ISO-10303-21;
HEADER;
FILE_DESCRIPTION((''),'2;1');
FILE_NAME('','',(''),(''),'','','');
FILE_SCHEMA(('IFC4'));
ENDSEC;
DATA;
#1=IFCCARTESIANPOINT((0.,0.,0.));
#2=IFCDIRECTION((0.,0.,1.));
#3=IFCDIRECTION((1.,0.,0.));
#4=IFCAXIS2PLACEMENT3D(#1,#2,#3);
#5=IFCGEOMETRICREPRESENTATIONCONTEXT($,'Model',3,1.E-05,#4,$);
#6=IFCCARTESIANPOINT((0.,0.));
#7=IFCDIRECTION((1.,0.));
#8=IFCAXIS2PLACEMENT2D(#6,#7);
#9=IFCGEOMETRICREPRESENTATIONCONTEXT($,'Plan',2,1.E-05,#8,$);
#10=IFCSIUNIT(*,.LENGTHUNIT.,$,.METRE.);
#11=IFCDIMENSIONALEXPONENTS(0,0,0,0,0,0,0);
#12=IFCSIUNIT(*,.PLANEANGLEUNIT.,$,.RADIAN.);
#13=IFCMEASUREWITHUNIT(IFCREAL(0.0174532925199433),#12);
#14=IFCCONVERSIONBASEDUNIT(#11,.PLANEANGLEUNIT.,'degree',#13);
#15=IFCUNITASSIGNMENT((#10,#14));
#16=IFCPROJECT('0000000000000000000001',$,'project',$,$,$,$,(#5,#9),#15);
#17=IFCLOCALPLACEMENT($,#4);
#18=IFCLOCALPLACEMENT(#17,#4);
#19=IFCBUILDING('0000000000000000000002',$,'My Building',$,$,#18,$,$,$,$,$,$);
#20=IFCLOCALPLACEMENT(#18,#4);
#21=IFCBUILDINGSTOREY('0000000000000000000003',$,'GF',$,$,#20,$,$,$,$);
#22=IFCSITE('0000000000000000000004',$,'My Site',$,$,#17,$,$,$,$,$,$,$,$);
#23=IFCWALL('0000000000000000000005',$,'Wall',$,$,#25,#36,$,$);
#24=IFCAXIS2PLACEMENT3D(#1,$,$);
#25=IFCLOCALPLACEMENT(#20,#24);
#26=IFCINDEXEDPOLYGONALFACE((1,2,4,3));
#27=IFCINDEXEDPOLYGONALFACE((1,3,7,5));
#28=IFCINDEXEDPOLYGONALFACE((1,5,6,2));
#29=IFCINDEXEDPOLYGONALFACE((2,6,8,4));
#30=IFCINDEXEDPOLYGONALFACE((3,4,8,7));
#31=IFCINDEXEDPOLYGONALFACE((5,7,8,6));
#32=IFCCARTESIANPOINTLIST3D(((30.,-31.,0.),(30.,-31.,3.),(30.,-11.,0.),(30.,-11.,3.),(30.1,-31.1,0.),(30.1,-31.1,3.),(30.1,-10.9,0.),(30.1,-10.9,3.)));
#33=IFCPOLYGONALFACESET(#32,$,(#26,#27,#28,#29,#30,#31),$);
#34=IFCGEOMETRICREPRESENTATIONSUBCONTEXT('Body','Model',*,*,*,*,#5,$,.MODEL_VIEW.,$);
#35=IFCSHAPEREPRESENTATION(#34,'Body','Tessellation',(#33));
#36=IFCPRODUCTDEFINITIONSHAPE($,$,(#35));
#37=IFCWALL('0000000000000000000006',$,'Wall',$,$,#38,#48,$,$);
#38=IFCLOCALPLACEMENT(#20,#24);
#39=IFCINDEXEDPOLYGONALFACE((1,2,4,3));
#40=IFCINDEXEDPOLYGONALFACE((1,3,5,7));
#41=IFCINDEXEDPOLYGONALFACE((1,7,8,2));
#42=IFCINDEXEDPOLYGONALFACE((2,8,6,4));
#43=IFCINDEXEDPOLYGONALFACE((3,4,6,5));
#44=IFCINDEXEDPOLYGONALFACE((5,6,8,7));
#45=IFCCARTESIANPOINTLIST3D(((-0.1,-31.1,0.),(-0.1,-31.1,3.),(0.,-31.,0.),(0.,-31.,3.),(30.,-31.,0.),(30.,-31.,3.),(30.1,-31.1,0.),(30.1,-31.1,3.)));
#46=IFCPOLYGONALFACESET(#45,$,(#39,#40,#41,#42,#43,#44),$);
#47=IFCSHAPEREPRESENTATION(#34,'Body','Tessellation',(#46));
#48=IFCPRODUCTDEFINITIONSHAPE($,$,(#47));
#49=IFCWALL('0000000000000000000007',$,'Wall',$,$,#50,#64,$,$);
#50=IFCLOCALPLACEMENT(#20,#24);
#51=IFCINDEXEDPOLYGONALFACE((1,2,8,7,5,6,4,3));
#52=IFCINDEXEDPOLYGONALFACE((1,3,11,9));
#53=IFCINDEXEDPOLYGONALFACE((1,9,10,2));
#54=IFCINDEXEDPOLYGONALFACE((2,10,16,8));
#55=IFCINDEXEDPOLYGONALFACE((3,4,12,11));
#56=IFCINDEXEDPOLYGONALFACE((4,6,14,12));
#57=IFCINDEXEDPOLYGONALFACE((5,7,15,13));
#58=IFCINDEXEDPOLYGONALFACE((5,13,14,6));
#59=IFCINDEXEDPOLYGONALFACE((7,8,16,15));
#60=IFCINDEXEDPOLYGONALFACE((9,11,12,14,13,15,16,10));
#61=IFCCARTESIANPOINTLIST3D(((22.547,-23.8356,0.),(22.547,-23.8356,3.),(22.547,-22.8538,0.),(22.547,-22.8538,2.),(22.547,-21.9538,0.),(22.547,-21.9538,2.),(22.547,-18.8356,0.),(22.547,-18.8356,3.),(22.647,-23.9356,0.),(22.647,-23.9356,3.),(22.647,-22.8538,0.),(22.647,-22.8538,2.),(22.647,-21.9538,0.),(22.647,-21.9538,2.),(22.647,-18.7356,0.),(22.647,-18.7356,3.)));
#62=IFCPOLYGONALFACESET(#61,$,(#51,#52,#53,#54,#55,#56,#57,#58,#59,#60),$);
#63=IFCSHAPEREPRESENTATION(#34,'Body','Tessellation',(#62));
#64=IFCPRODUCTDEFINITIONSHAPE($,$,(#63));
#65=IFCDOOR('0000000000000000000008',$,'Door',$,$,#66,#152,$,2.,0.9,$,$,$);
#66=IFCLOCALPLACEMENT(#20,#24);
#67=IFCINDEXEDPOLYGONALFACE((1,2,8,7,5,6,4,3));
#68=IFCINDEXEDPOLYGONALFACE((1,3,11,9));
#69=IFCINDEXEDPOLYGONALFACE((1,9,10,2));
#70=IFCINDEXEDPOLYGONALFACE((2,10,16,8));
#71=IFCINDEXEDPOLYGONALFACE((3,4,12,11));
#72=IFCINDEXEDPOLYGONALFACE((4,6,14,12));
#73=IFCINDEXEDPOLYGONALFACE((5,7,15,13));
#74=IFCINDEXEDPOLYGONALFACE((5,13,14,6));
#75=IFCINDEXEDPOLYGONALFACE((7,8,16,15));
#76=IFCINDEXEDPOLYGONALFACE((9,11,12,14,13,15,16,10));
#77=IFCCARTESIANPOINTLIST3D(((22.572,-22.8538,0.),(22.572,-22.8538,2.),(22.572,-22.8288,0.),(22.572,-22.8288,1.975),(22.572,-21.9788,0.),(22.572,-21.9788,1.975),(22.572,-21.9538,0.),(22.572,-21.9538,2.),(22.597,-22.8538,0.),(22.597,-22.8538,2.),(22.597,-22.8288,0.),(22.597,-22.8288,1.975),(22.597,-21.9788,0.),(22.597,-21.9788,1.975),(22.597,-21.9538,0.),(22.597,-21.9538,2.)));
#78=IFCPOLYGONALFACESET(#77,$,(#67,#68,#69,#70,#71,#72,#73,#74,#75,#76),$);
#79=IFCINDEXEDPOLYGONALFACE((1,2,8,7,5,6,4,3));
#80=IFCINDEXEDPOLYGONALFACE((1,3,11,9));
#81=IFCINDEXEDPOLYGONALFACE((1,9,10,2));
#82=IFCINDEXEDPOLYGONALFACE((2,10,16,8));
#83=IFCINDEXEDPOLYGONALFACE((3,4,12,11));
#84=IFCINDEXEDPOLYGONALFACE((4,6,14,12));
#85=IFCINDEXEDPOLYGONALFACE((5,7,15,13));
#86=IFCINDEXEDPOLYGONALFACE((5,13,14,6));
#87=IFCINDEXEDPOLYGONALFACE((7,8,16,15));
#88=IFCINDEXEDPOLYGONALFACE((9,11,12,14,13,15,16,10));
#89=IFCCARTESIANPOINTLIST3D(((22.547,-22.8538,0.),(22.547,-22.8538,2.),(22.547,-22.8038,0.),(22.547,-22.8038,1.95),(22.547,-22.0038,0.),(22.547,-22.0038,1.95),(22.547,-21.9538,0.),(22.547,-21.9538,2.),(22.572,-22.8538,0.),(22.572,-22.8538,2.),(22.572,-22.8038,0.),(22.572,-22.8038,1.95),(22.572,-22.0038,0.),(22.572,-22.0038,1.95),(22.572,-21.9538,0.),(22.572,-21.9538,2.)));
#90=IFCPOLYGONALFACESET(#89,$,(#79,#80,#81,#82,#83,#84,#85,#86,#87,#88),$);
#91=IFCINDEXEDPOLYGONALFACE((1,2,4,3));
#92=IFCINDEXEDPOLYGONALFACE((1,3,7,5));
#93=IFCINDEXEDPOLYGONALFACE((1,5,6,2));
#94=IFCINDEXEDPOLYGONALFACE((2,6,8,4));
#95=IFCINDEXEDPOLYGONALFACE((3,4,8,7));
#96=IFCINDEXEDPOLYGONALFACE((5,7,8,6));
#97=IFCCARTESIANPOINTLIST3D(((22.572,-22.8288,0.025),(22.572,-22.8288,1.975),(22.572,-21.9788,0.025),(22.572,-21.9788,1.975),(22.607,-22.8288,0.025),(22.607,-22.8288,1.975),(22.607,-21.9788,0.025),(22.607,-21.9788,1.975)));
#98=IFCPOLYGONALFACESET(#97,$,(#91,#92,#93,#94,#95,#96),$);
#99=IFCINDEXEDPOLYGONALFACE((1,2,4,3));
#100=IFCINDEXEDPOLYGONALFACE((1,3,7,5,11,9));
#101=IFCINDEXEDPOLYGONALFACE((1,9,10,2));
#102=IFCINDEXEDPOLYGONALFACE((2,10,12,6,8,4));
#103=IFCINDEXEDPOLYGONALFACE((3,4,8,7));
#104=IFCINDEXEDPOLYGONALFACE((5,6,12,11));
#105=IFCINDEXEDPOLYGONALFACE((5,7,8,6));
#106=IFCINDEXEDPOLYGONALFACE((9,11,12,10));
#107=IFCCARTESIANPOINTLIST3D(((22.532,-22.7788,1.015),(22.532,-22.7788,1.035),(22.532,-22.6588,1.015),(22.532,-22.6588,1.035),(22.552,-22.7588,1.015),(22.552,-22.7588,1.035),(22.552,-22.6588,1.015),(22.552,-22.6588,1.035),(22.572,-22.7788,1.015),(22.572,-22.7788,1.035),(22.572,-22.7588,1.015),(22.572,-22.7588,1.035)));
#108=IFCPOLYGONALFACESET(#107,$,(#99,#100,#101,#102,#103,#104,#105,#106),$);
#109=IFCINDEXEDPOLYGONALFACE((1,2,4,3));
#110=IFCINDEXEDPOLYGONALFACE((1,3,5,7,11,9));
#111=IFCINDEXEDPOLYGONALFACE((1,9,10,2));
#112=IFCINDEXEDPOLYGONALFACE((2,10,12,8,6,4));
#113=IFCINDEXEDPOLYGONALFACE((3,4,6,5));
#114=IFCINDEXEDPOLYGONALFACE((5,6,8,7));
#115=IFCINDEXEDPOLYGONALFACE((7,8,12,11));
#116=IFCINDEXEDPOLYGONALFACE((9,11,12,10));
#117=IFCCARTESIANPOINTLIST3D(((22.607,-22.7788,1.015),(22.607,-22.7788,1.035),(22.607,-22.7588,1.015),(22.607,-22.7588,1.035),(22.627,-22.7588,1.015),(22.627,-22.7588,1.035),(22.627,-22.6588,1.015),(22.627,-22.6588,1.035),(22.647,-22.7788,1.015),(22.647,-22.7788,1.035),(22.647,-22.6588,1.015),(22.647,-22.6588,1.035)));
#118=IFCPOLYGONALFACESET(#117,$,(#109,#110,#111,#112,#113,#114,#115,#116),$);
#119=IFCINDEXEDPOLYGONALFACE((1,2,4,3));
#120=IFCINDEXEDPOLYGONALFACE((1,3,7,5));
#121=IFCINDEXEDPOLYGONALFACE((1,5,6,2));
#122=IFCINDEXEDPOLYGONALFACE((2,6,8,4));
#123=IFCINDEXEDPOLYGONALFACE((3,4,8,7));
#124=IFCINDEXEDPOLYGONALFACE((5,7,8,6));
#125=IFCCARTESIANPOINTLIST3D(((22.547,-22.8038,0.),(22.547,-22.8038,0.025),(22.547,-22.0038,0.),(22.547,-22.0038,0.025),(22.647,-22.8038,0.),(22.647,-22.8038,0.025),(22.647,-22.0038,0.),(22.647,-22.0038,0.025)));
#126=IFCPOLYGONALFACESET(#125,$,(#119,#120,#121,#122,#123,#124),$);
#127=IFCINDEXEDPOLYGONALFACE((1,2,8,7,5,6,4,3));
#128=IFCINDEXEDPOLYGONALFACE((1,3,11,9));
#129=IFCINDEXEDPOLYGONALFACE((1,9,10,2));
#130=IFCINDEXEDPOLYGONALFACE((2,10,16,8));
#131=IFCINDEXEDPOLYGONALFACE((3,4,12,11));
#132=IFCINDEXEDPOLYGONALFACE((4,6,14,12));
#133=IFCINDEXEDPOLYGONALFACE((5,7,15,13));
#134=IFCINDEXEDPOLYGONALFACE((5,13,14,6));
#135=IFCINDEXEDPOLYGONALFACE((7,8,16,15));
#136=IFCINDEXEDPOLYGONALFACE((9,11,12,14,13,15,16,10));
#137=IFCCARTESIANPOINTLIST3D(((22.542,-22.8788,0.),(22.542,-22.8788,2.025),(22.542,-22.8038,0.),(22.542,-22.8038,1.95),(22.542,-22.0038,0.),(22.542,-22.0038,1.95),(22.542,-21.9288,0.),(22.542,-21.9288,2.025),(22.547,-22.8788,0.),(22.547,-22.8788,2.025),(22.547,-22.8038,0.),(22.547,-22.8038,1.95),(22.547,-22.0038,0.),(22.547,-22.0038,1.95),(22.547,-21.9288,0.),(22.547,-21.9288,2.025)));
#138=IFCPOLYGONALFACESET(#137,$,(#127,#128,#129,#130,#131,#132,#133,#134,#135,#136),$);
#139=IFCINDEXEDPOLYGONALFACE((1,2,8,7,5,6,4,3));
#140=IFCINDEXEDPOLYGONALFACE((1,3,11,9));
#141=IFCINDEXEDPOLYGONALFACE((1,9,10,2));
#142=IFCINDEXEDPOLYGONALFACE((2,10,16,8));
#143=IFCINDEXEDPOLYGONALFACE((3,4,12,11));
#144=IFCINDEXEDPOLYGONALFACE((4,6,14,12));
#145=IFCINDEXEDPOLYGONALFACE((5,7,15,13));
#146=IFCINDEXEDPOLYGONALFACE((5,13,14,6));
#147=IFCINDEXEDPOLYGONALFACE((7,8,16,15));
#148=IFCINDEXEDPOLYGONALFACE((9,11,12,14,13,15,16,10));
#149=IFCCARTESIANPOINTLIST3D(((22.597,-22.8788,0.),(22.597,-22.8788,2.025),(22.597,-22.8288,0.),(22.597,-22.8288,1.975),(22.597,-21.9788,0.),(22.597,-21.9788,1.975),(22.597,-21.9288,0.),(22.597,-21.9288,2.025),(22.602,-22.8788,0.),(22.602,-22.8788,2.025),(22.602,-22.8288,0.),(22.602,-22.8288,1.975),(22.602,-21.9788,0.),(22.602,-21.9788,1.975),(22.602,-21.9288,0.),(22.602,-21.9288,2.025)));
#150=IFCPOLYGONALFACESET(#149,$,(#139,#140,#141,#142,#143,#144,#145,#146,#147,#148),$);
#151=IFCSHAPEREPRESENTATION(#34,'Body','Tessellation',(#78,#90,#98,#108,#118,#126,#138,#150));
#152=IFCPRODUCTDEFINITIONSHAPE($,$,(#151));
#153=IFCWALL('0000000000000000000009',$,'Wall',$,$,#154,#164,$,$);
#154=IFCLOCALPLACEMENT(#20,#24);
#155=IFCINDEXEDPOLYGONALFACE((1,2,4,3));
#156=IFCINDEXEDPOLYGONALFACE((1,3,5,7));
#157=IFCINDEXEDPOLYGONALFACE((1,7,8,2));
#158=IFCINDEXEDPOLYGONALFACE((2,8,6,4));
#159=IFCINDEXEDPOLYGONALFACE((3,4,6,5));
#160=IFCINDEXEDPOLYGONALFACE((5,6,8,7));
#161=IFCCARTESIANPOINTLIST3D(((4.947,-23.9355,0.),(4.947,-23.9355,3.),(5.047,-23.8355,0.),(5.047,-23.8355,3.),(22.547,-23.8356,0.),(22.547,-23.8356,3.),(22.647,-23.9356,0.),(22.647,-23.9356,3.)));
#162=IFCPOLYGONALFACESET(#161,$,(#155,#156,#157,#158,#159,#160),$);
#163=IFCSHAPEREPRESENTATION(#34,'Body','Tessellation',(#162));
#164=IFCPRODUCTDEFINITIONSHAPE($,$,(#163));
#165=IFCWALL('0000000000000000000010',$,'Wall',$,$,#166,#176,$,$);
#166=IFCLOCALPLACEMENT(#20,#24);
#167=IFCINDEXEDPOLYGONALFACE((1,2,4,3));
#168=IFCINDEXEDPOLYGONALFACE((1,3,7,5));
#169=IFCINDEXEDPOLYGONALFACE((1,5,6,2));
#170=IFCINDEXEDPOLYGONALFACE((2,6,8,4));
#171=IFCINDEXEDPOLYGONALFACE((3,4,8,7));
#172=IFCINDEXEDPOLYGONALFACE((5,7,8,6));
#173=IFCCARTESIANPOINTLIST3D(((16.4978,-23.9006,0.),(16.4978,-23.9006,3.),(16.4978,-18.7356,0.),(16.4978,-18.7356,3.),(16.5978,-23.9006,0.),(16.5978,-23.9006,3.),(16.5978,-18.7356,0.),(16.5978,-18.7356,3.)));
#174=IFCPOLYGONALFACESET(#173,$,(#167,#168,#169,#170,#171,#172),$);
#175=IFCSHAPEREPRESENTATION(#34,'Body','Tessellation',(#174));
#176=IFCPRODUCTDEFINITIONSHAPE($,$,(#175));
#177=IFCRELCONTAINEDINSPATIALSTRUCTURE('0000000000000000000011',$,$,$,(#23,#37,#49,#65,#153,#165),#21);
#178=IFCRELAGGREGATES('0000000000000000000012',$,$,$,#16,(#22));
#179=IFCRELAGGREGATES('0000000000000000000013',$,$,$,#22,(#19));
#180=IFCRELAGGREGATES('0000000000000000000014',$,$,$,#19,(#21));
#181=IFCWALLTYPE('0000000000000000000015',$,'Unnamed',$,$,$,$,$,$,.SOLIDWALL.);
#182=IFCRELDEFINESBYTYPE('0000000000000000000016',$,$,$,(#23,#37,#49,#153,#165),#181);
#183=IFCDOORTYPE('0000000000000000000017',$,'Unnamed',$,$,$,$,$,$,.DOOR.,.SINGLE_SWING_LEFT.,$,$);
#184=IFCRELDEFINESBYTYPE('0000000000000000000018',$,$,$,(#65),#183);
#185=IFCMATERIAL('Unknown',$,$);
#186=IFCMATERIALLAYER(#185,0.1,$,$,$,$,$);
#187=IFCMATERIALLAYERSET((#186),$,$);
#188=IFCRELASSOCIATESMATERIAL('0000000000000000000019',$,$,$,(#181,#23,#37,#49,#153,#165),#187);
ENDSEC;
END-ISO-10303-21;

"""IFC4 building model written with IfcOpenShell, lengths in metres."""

from ifc_helpers import new_model, entity, si_unit, converted_unit, frame, origin_with_axes, origin_2d_with_axis, place, context, subcontext, project, spatial, line, indexed_curve, outline, extrude, shape, source, transform, mapped, material, layer, layer_set, layer_usage, type_object, type_shapes, element, fill, save


model = new_model("IFC4")

# Units and contexts
model_context = context("Model", 3, precision=1e-05, world=origin_with_axes())
plan_context = context("Plan", 2, precision=1e-05, world=origin_2d_with_axis())
body_context_1 = subcontext(model_context, "Body", "Model", "MODEL_VIEW")
body_context_2 = subcontext(plan_context, "Body", "Plan", "PLAN_VIEW")
ifc_project = project(units=[si_unit("LENGTHUNIT", "METRE"), converted_unit("PLANEANGLEUNIT", "degree", entity("IfcReal", 0.0174532925199433), si_unit("PLANEANGLEUNIT", "RADIAN"), dimensions=[0, 0, 0, 0, 0, 0, 0])], contexts=[model_context, plan_context])

# Site, building, storey
site_placement = place(None, origin_with_axes())
site = spatial("IfcSite", under=ifc_project, at=site_placement, Name="My Site")
building_placement = place(site_placement, origin_with_axes())
building = spatial("IfcBuilding", under=site, at=building_placement, Name="My Building")
storey_placement = place(building_placement, origin_with_axes())
storey = spatial("IfcBuildingStorey", under=building, at=storey_placement, Name="GF")

# Walls
ifc_material = material(Name="Unknown")
ifc_layer = layer(ifc_material, 0.1)
ifc_layer_set = layer_set([ifc_layer])
ifc_layer_usage_1 = layer_usage(ifc_layer_set, "AXIS2", "POSITIVE", 0.0)
wall_type = type_object("IfcWallType", Name="Unnamed", PredefinedType="SOLIDWALL", material=ifc_layer_set)
wall_1_placement = place(storey_placement, frame((30.0, -11.0, 0.0), z_axis=(0.0, 0.0, 1.0), x_axis=(0.0, -1.0, 0.0)))
element("IfcWall", 1, at=wall_1_placement, inside=storey, type_object=wall_type, material=ifc_layer_usage_1, Name="Wall", context=body_context_1, shape_type="SweptSolid", body=[
    extrude(outline(indexed_curve([(0.0, 0.0), (-0.1, 0.1), (20.1, 0.1), (20.0, 0.0)], segments=[line(1, 2, 3, 4, 1)])), origin_with_axes(), (0.0, 0.0, 1.0), 3.0),
])
ifc_layer_usage_2 = layer_usage(ifc_layer_set, "AXIS2", "POSITIVE", 0.0)
wall_2_placement = place(storey_placement, frame((30.0, -31.0, 0.0), z_axis=(0.0, 0.0, 1.0), x_axis=(-1.0, 0.0, 0.0)))
element("IfcWall", 2, at=wall_2_placement, inside=storey, type_object=wall_type, material=ifc_layer_usage_2, Name="Wall", context=body_context_1, shape_type="SweptSolid", body=[
    extrude(outline(indexed_curve([(0.0, 0.0), (-0.1, 0.1), (30.1, 0.1), (30.0, 0.0)], segments=[line(1, 2, 3, 4, 1)])), origin_with_axes(), (0.0, 0.0, 1.0), 3.0),
])

# Wall, opening, door
ifc_layer_usage_3 = layer_usage(ifc_layer_set, "AXIS2", "POSITIVE", 0.0)
wall_3_placement = place(storey_placement, frame((22.547, -18.8356, 0.0), z_axis=(0.0, 0.0, 1.0), x_axis=(0.0, -1.0, 0.0)))
wall_3 = element("IfcWall", 3, at=wall_3_placement, inside=storey, type_object=wall_type, material=ifc_layer_usage_3, Name="Wall", context=body_context_1, shape_type="SweptSolid", body=[
    extrude(outline(indexed_curve([(0.0, 0.0), (-0.1, 0.1), (5.1, 0.1), (5.0, 0.0)], segments=[line(1, 2, 3, 4, 1)])), origin_with_axes(), (0.0, 0.0, 1.0), 3.0),
])
shared_shape_1 = source(origin_with_axes(), body_context_1, "Body", "SweptSolid", [
    extrude(outline(indexed_curve([(0.0, 0.0), (0.9, 0.0), (0.9, 2.0), (0.0, 2.0)], segments=[line(1, 2, 3, 4, 1)])), frame((0.0, -0.6, 0.0), z_axis=(0.0, -1.0, 0.0), x_axis=(1.0, 0.0, 0.0)), (0.0, 0.0, -1.0), 1.2),
])
opening_1_placement = place(wall_3_placement, frame((3.1182, 0.0, 0.0), z_axis=(0.0, 0.0, 1.0), x_axis=(1.0, 0.0, 0.0)))
opening_1 = element("IfcOpeningElement", 4, at=opening_1_placement, cuts=wall_3, PredefinedType="OPENING", context=body_context_1, shape_type="MappedRepresentation", body=[
    mapped(shared_shape_1, transform((0.0, 0.0, 0.0), x_axis=(1.0, 0.0, 0.0), y_axis=(0.0, 1.0, 0.0), z_axis=(0.0, 0.0, 1.0), scale=1.0)),
])
door_type = type_object("IfcDoorType", Name="Unnamed", OperationType="SINGLE_SWING_LEFT", PredefinedType="DOOR")
shared_shape_2 = source(origin_with_axes(), body_context_1, "Body", "SweptSolid", [
    extrude(outline(indexed_curve([(0.0, 0.0), (0.0, 2.0), (0.9, 2.0), (0.9, 0.0), (0.875, 0.0), (0.875, 1.975), (0.025, 1.975), (0.025, 0.0)], segments=[line(1, 2, 3, 4, 5, 6, 7, 8, 1)])), frame((0.0, 0.025, 0.0), z_axis=(0.0, -1.0, 0.0), x_axis=(1.0, 0.0, 0.0)), (0.0, 0.0, -1.0), 0.025),
    extrude(outline(indexed_curve([(0.0, 0.0), (0.0, 2.0), (0.9, 2.0), (0.9, 0.0), (0.85, 0.0), (0.85, 1.95), (0.05, 1.95), (0.05, 0.0)], segments=[line(1, 2, 3, 4, 5, 6, 7, 8, 1)])), frame((0.0, 0.0, 0.0), z_axis=(0.0, -1.0, 0.0), x_axis=(1.0, 0.0, 0.0)), (0.0, 0.0, -1.0), 0.025),
    extrude(outline(indexed_curve([(0.0, 0.0), (0.85, 0.0), (0.85, 0.035), (0.0, 0.035)], segments=[line(1, 2, 3, 4, 1)])), frame((0.025, 0.025, 0.025), z_axis=(0.0, 0.0, 1.0), x_axis=(1.0, 0.0, 0.0)), (0.0, 0.0, 1.0), 1.95),
    extrude(outline(indexed_curve([(0.0, 0.0), (0.0, -0.04), (-0.12, -0.04), (-0.12, -0.02), (-0.02, -0.02), (-0.02, 0.0)], segments=[line(1, 2, 3, 4, 5, 6, 1)])), frame((0.825, 0.025, 1.015), z_axis=(0.0, 0.0, 1.0), x_axis=(1.0, 0.0, 0.0)), (0.0, 0.0, 1.0), 0.02),
    extrude(outline(indexed_curve([(0.0, 0.0), (0.0, 0.04), (-0.12, 0.04), (-0.12, 0.02), (-0.02, 0.02), (-0.02, 0.0)], segments=[line(1, 2, 3, 4, 5, 6, 1)])), frame((0.825, 0.06, 1.015), z_axis=(0.0, 0.0, 1.0), x_axis=(1.0, 0.0, 0.0)), (0.0, 0.0, 1.0), 0.02),
    extrude(outline(indexed_curve([(0.0, 0.0), (0.8, 0.0), (0.8, 0.1), (0.0, 0.1)], segments=[line(1, 2, 3, 4, 1)])), frame((0.05, 0.0, 0.0), z_axis=(0.0, 0.0, 1.0), x_axis=(1.0, 0.0, 0.0)), (0.0, 0.0, 1.0), 0.025),
    extrude(outline(indexed_curve([(0.0, 0.0), (0.0, 2.025), (0.95, 2.025), (0.95, 0.0), (0.875, 0.0), (0.875, 1.95), (0.075, 1.95), (0.075, 0.0)], segments=[line(1, 2, 3, 4, 5, 6, 7, 8, 1)])), frame((-0.025, -0.005, 0.0), z_axis=(0.0, -1.0, 0.0), x_axis=(1.0, 0.0, 0.0)), (0.0, 0.0, -1.0), 0.005),
    extrude(outline(indexed_curve([(0.0, 0.0), (0.0, 2.025), (0.95, 2.025), (0.95, 0.0), (0.9, 0.0), (0.9, 1.975), (0.05, 1.975), (0.05, 0.0)], segments=[line(1, 2, 3, 4, 5, 6, 7, 8, 1)])), frame((-0.025, 0.05, 0.0), z_axis=(0.0, -1.0, 0.0), x_axis=(1.0, 0.0, 0.0)), (0.0, 0.0, -1.0), 0.005),
])
shared_shape_3 = source(origin_with_axes(), body_context_2, "Body", "Curve2D", [
    entity("IfcIndexedPolyCurve", entity("IfcCartesianPointList2D", [[0.0, 0.0], [0.0, 0.05], [0.025, 0.05], [0.025, 0.025], [0.05, 0.025], [0.05, 0.0]]), [entity("IfcLineIndex", [1, 2, 3, 4, 5, 6, 1])]),
    entity("IfcIndexedPolyCurve", entity("IfcCartesianPointList2D", [[0.9, 0.0], [0.9, 0.05], [0.875, 0.05], [0.875, 0.025], [0.85, 0.025], [0.85, 0.0]]), [entity("IfcLineIndex", [1, 2, 3, 4, 5, 6, 1])]),
    entity("IfcTrimmedCurve", entity("IfcEllipse", entity("IfcAxis2Placement2D", entity("IfcCartesianPoint", [0.06, 0.05]), entity("IfcDirection", [1.0, 0.0])), 0.815, 0.85), [entity("IfcCartesianPoint", [0.875, 0.05])], [entity("IfcCartesianPoint", [0.06, 0.9])], True, "CARTESIAN"),
    entity("IfcIndexedPolyCurve", entity("IfcCartesianPointList2D", [[0.025, 0.05], [0.06, 0.05], [0.06, 0.9], [0.025, 0.9]]), [entity("IfcLineIndex", [1, 2, 3, 4, 1])]),
])
type_shapes(door_type, [shared_shape_2, shared_shape_3])
door_1_placement = place(opening_1_placement, frame((0.0, 0.0, 0.0), z_axis=(0.0, 0.0, 1.0), x_axis=(1.0, 0.0, 0.0)))
door_1 = element("IfcDoor", 5, at=door_1_placement, inside=storey, type_object=door_type, Name="Door", OverallHeight=2.0, OverallWidth=0.9, shapes=[
    shape(body_context_1, "Body", "MappedRepresentation", [mapped(shared_shape_2, transform((0.0, 0.0, 0.0), x_axis=(1.0, 0.0, 0.0), y_axis=(0.0, 1.0, 0.0), z_axis=(0.0, 0.0, 1.0), scale=1.0))]),
    shape(body_context_2, "Body", "MappedRepresentation", [mapped(shared_shape_3, transform((0.0, 0.0, 0.0), x_axis=(1.0, 0.0, 0.0), y_axis=(0.0, 1.0, 0.0), z_axis=(0.0, 0.0, 1.0), scale=1.0))]),
])
fill(opening_1, door_1)

# Walls
ifc_layer_usage_4 = layer_usage(ifc_layer_set, "AXIS2", "POSITIVE", 0.0)
wall_4_placement = place(storey_placement, frame((22.547, -23.8356, 0.0), z_axis=(0.0, 0.0, 1.0), x_axis=(-1.0, 0.0, 0.0)))
element("IfcWall", 6, at=wall_4_placement, inside=storey, type_object=wall_type, material=ifc_layer_usage_4, Name="Wall", context=body_context_1, shape_type="SweptSolid", body=[
    extrude(outline(indexed_curve([(0.0, 0.0), (-0.1, 0.1), (17.6, 0.1), (17.5, 0.0)], segments=[line(1, 2, 3, 4, 1)])), origin_with_axes(), (0.0, 0.0, 1.0), 3.0),
])
ifc_layer_usage_5 = layer_usage(ifc_layer_set, "AXIS2", "POSITIVE", 0.0)
wall_5_placement = place(storey_placement, frame((16.4978, -18.7356, 0.0), z_axis=(0.0, 0.0, 1.0), x_axis=(0.0, -1.0, 0.0)))
element("IfcWall", 7, at=wall_5_placement, inside=storey, type_object=wall_type, material=ifc_layer_usage_5, Name="Wall", context=body_context_1, shape_type="SweptSolid", body=[
    extrude(outline(indexed_curve([(0.0, 0.0), (0.0, 0.1), (5.1651, 0.1), (5.1651, 0.0)], segments=[line(1, 2, 3, 4, 1)])), origin_with_axes(), (0.0, 0.0, 1.0), 3.0),
])

save(model, "model.ifc")
